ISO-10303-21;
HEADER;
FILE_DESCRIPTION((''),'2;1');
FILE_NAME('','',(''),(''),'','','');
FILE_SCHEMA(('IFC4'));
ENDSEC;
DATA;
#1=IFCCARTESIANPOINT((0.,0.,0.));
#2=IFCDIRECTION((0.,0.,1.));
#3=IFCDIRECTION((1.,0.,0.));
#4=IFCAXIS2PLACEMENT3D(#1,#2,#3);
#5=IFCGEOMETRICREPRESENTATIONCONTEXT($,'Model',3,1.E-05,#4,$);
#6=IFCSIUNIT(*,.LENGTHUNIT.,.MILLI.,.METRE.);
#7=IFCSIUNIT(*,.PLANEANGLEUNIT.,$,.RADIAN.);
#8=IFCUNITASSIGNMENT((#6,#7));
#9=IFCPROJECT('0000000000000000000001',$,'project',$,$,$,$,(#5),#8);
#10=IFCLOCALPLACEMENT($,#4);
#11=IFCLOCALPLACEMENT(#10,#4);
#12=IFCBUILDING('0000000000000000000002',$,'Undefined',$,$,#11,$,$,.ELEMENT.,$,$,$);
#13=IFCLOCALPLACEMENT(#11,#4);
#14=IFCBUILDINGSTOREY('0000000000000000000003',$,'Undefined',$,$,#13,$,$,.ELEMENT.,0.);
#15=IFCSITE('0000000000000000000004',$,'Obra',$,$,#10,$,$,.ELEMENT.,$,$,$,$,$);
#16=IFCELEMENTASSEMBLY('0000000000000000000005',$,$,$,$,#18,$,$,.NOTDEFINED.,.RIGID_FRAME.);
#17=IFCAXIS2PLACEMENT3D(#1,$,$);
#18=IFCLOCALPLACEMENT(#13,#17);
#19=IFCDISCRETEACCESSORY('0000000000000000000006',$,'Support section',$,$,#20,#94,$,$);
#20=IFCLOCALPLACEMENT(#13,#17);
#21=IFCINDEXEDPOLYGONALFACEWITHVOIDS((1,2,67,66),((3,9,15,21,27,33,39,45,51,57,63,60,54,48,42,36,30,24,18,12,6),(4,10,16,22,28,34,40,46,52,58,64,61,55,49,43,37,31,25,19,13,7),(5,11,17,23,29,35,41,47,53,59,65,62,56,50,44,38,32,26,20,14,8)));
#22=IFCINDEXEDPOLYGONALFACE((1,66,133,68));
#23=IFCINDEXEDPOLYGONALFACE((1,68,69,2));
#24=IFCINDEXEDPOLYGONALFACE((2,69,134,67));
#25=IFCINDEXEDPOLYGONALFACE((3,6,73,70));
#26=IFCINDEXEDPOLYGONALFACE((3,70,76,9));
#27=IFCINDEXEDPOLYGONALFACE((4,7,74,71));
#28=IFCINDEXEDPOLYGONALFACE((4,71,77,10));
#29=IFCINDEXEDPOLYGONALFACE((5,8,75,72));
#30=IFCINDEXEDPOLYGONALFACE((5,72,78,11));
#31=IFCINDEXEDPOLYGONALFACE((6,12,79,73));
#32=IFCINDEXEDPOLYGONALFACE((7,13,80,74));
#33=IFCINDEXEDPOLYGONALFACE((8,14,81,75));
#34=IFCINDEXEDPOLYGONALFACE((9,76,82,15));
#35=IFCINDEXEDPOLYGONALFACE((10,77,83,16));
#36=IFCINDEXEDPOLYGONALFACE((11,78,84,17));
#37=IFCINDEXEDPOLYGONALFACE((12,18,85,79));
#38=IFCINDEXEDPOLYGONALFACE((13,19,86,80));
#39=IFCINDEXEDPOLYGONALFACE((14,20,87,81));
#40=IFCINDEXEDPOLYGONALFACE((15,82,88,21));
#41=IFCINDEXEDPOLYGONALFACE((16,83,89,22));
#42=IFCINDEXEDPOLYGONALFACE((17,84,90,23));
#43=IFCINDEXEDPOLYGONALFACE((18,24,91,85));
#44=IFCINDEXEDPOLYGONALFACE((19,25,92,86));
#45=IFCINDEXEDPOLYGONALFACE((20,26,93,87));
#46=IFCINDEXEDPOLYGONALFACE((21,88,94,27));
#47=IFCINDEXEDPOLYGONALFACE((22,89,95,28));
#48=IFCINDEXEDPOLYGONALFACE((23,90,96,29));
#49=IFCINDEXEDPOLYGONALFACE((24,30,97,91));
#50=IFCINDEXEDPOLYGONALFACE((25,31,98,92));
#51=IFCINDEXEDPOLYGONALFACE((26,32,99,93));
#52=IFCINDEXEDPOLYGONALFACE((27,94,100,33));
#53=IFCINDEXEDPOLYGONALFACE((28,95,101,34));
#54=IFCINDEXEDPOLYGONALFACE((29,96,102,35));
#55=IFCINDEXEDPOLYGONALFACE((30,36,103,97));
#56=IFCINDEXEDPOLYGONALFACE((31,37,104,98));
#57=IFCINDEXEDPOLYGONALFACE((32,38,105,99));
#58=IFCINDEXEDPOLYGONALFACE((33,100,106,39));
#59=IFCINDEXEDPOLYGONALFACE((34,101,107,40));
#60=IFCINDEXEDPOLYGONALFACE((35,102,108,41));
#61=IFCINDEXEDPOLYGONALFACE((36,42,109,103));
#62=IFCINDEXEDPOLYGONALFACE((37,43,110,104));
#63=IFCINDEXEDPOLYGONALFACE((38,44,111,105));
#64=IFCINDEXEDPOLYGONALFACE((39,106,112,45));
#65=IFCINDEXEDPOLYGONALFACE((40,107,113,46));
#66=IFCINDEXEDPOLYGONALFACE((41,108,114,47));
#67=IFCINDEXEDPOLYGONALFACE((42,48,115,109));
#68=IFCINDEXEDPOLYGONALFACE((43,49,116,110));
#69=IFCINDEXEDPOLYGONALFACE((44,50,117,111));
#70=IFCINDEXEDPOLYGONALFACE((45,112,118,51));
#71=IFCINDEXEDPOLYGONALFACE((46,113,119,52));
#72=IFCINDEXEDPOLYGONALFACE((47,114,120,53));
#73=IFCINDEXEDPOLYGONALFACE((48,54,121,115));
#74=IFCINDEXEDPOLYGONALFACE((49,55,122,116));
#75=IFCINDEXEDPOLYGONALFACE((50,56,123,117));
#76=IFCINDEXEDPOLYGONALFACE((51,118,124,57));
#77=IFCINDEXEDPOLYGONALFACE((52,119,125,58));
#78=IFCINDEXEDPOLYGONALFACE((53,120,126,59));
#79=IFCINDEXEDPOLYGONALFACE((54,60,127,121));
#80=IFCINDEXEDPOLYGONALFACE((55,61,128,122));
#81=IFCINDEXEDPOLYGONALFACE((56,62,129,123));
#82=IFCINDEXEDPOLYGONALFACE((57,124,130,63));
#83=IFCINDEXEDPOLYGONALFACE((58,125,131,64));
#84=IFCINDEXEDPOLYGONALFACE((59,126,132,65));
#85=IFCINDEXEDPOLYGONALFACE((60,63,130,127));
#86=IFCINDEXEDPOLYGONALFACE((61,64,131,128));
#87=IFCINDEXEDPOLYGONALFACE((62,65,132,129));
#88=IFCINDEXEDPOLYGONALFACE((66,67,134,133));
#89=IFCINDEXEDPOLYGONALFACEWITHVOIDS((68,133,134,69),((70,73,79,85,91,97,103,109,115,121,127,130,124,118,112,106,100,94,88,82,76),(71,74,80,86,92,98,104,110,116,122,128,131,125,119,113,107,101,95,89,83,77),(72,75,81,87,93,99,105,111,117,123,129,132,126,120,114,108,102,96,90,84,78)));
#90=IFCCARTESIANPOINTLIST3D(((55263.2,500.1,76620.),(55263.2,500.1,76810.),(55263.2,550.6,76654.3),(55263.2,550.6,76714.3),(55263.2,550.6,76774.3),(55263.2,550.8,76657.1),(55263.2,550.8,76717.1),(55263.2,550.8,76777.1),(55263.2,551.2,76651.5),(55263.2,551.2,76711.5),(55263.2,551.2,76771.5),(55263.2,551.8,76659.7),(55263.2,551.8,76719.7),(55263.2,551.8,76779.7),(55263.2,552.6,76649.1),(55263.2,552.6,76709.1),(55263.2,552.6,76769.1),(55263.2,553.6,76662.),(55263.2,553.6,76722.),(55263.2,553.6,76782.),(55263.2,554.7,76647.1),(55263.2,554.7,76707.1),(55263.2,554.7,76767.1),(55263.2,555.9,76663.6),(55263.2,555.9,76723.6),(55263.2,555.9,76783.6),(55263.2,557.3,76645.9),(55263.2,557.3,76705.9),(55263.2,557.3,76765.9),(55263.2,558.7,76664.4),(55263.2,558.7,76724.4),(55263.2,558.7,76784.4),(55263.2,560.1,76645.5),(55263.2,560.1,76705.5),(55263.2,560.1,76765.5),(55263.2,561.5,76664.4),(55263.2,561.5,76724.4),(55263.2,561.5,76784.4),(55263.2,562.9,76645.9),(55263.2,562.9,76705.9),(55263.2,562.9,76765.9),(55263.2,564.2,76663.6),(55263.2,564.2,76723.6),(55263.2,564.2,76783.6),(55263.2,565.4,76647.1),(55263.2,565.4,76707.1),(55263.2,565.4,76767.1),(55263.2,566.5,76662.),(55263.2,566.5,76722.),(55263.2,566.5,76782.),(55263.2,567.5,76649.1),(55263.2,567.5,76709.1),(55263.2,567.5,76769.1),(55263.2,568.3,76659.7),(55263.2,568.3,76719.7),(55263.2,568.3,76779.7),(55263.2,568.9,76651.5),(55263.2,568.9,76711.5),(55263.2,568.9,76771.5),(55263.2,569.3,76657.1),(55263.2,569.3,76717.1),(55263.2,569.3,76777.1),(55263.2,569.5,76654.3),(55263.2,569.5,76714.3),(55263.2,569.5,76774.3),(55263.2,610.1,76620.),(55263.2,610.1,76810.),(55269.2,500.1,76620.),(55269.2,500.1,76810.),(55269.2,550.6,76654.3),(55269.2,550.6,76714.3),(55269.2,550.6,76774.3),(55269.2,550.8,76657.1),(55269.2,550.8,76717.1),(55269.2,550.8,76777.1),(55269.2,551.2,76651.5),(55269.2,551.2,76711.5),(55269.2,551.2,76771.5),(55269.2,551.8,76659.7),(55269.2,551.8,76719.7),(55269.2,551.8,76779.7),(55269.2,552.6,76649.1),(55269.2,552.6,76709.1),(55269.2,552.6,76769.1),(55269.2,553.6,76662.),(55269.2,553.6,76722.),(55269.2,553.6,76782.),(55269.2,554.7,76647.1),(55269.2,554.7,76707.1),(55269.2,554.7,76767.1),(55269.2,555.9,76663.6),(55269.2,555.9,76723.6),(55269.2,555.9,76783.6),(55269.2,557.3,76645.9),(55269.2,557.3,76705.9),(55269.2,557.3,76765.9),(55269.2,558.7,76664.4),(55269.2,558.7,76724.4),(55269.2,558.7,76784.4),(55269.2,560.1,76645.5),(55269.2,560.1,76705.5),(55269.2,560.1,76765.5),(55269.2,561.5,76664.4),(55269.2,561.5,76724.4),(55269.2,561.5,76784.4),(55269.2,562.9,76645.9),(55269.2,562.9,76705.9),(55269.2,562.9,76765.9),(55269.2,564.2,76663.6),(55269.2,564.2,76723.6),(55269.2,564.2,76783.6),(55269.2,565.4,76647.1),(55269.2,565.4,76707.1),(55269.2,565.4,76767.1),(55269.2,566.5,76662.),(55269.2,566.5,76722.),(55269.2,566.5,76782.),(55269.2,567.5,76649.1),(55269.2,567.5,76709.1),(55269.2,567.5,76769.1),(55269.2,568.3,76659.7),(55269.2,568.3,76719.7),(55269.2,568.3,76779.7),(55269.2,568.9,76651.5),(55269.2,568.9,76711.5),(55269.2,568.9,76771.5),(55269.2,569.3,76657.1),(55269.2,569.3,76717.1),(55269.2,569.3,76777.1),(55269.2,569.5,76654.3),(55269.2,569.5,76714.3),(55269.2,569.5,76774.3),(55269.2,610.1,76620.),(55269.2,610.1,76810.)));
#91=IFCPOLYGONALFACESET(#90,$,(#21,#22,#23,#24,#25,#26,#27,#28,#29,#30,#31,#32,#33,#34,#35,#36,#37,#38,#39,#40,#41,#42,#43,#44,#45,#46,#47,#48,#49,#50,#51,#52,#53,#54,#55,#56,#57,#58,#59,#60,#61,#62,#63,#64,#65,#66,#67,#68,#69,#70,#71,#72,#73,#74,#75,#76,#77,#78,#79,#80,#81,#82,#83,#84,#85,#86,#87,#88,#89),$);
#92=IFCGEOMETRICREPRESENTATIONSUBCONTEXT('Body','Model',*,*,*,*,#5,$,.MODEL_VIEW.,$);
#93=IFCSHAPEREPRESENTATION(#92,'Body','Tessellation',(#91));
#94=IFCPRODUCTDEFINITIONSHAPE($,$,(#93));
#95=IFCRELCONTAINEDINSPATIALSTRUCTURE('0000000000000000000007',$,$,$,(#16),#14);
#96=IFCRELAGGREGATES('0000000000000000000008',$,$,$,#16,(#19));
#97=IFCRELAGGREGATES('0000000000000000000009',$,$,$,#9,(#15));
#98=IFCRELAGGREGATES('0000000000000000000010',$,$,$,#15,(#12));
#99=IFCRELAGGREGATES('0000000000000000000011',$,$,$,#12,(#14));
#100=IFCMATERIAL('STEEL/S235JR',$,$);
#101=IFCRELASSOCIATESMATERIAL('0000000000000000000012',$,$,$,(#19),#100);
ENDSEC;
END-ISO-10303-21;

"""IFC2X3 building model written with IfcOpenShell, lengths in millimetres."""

from ifc_helpers import new_model, si_unit, frame, origin_with_axes, origin_2d_with_axis, place, context, subcontext, project, spatial, rectangle, circle, extrude, source, transform, mapped, material, element, aggregate, save


model = new_model("IFC2X3")

# Units and contexts
model_context = context("Model", 3, precision=1e-05, world=origin_with_axes())
body_context = subcontext(model_context, "Body", "Model", "MODEL_VIEW")
ifc_project = project(units=[si_unit("LENGTHUNIT", "METRE", prefix="MILLI"), si_unit("PLANEANGLEUNIT", "RADIAN")], contexts=[model_context])

# Site, building, storey
site_placement = place(None, origin_with_axes())
site = spatial("IfcSite", under=ifc_project, at=site_placement, Name="Obra", CompositionType="ELEMENT")
building_placement = place(site_placement, origin_with_axes())
building = spatial("IfcBuilding", under=site, at=building_placement, Name="Undefined", CompositionType="ELEMENT")
storey_placement = place(building_placement, origin_with_axes())
storey = spatial("IfcBuildingStorey", under=building, at=storey_placement, Name="Undefined", CompositionType="ELEMENT", Elevation=0.0)

# Element assembly
ifc_material_1 = material(Name="STEEL/S235JR")
assembly_1_placement = place(storey_placement, origin_with_axes())
assembly_1 = element("IfcElementAssembly", 1, at=assembly_1_placement, inside=storey, AssemblyPlace="NOTDEFINED", PredefinedType="RIGID_FRAME")

# Shared definitions
shared_shape_1 = source(origin_with_axes(), body_context, "Body", "SweptSolid", [
    extrude(circle(Radius=9.5, at=origin_2d_with_axis()), frame((0.0, -9.2, 0.0), z_axis=(0.0, 1.0, 0.0), x_axis=(1.0, 0.0, 0.0)), (0.0, 0.0, 1.0), 6.2),
])

# Discrete accessory, opening
discrete_accessory_1_placement = place(assembly_1_placement, frame((55266.2, 555.1, 76620.0), z_axis=(0.0, 0.0, 1.0), x_axis=(0.000002, -1.0, 0.0)))
discrete_accessory_1 = element("IfcDiscreteAccessory", 2, at=discrete_accessory_1_placement, material=ifc_material_1, Name="Support section", context=body_context, shape_type="SweptSolid", body=[
    extrude(rectangle(XDim=6.0, YDim=110.0, at=origin_2d_with_axis()), frame((0.0, 0.0, 190.0), z_axis=(0.0, 0.0, -1.0), x_axis=(0.0, 1.0, 0.0)), (0.0, 0.0, 1.0), 190.0),
])
opening_1_placement = place(assembly_1_placement, frame((55260.1, 510.1, 76835.0), z_axis=(-0.000002, 1.0, 0.0), x_axis=(0.0, 0.0, -1.0)))
element("IfcOpeningElement", 3, at=opening_1_placement, cuts=discrete_accessory_1, ObjectType="Opening", context=body_context, shape_type="MappedRepresentation", body=[
    mapped(shared_shape_1, transform((60.0, 0.0, 50.0))),
    mapped(shared_shape_1, transform((120.0, 0.0, 50.0))),
    mapped(shared_shape_1, transform((180.0, 0.0, 50.0))),
])
aggregate(assembly_1, [discrete_accessory_1])

save(model, "model.ifc")
